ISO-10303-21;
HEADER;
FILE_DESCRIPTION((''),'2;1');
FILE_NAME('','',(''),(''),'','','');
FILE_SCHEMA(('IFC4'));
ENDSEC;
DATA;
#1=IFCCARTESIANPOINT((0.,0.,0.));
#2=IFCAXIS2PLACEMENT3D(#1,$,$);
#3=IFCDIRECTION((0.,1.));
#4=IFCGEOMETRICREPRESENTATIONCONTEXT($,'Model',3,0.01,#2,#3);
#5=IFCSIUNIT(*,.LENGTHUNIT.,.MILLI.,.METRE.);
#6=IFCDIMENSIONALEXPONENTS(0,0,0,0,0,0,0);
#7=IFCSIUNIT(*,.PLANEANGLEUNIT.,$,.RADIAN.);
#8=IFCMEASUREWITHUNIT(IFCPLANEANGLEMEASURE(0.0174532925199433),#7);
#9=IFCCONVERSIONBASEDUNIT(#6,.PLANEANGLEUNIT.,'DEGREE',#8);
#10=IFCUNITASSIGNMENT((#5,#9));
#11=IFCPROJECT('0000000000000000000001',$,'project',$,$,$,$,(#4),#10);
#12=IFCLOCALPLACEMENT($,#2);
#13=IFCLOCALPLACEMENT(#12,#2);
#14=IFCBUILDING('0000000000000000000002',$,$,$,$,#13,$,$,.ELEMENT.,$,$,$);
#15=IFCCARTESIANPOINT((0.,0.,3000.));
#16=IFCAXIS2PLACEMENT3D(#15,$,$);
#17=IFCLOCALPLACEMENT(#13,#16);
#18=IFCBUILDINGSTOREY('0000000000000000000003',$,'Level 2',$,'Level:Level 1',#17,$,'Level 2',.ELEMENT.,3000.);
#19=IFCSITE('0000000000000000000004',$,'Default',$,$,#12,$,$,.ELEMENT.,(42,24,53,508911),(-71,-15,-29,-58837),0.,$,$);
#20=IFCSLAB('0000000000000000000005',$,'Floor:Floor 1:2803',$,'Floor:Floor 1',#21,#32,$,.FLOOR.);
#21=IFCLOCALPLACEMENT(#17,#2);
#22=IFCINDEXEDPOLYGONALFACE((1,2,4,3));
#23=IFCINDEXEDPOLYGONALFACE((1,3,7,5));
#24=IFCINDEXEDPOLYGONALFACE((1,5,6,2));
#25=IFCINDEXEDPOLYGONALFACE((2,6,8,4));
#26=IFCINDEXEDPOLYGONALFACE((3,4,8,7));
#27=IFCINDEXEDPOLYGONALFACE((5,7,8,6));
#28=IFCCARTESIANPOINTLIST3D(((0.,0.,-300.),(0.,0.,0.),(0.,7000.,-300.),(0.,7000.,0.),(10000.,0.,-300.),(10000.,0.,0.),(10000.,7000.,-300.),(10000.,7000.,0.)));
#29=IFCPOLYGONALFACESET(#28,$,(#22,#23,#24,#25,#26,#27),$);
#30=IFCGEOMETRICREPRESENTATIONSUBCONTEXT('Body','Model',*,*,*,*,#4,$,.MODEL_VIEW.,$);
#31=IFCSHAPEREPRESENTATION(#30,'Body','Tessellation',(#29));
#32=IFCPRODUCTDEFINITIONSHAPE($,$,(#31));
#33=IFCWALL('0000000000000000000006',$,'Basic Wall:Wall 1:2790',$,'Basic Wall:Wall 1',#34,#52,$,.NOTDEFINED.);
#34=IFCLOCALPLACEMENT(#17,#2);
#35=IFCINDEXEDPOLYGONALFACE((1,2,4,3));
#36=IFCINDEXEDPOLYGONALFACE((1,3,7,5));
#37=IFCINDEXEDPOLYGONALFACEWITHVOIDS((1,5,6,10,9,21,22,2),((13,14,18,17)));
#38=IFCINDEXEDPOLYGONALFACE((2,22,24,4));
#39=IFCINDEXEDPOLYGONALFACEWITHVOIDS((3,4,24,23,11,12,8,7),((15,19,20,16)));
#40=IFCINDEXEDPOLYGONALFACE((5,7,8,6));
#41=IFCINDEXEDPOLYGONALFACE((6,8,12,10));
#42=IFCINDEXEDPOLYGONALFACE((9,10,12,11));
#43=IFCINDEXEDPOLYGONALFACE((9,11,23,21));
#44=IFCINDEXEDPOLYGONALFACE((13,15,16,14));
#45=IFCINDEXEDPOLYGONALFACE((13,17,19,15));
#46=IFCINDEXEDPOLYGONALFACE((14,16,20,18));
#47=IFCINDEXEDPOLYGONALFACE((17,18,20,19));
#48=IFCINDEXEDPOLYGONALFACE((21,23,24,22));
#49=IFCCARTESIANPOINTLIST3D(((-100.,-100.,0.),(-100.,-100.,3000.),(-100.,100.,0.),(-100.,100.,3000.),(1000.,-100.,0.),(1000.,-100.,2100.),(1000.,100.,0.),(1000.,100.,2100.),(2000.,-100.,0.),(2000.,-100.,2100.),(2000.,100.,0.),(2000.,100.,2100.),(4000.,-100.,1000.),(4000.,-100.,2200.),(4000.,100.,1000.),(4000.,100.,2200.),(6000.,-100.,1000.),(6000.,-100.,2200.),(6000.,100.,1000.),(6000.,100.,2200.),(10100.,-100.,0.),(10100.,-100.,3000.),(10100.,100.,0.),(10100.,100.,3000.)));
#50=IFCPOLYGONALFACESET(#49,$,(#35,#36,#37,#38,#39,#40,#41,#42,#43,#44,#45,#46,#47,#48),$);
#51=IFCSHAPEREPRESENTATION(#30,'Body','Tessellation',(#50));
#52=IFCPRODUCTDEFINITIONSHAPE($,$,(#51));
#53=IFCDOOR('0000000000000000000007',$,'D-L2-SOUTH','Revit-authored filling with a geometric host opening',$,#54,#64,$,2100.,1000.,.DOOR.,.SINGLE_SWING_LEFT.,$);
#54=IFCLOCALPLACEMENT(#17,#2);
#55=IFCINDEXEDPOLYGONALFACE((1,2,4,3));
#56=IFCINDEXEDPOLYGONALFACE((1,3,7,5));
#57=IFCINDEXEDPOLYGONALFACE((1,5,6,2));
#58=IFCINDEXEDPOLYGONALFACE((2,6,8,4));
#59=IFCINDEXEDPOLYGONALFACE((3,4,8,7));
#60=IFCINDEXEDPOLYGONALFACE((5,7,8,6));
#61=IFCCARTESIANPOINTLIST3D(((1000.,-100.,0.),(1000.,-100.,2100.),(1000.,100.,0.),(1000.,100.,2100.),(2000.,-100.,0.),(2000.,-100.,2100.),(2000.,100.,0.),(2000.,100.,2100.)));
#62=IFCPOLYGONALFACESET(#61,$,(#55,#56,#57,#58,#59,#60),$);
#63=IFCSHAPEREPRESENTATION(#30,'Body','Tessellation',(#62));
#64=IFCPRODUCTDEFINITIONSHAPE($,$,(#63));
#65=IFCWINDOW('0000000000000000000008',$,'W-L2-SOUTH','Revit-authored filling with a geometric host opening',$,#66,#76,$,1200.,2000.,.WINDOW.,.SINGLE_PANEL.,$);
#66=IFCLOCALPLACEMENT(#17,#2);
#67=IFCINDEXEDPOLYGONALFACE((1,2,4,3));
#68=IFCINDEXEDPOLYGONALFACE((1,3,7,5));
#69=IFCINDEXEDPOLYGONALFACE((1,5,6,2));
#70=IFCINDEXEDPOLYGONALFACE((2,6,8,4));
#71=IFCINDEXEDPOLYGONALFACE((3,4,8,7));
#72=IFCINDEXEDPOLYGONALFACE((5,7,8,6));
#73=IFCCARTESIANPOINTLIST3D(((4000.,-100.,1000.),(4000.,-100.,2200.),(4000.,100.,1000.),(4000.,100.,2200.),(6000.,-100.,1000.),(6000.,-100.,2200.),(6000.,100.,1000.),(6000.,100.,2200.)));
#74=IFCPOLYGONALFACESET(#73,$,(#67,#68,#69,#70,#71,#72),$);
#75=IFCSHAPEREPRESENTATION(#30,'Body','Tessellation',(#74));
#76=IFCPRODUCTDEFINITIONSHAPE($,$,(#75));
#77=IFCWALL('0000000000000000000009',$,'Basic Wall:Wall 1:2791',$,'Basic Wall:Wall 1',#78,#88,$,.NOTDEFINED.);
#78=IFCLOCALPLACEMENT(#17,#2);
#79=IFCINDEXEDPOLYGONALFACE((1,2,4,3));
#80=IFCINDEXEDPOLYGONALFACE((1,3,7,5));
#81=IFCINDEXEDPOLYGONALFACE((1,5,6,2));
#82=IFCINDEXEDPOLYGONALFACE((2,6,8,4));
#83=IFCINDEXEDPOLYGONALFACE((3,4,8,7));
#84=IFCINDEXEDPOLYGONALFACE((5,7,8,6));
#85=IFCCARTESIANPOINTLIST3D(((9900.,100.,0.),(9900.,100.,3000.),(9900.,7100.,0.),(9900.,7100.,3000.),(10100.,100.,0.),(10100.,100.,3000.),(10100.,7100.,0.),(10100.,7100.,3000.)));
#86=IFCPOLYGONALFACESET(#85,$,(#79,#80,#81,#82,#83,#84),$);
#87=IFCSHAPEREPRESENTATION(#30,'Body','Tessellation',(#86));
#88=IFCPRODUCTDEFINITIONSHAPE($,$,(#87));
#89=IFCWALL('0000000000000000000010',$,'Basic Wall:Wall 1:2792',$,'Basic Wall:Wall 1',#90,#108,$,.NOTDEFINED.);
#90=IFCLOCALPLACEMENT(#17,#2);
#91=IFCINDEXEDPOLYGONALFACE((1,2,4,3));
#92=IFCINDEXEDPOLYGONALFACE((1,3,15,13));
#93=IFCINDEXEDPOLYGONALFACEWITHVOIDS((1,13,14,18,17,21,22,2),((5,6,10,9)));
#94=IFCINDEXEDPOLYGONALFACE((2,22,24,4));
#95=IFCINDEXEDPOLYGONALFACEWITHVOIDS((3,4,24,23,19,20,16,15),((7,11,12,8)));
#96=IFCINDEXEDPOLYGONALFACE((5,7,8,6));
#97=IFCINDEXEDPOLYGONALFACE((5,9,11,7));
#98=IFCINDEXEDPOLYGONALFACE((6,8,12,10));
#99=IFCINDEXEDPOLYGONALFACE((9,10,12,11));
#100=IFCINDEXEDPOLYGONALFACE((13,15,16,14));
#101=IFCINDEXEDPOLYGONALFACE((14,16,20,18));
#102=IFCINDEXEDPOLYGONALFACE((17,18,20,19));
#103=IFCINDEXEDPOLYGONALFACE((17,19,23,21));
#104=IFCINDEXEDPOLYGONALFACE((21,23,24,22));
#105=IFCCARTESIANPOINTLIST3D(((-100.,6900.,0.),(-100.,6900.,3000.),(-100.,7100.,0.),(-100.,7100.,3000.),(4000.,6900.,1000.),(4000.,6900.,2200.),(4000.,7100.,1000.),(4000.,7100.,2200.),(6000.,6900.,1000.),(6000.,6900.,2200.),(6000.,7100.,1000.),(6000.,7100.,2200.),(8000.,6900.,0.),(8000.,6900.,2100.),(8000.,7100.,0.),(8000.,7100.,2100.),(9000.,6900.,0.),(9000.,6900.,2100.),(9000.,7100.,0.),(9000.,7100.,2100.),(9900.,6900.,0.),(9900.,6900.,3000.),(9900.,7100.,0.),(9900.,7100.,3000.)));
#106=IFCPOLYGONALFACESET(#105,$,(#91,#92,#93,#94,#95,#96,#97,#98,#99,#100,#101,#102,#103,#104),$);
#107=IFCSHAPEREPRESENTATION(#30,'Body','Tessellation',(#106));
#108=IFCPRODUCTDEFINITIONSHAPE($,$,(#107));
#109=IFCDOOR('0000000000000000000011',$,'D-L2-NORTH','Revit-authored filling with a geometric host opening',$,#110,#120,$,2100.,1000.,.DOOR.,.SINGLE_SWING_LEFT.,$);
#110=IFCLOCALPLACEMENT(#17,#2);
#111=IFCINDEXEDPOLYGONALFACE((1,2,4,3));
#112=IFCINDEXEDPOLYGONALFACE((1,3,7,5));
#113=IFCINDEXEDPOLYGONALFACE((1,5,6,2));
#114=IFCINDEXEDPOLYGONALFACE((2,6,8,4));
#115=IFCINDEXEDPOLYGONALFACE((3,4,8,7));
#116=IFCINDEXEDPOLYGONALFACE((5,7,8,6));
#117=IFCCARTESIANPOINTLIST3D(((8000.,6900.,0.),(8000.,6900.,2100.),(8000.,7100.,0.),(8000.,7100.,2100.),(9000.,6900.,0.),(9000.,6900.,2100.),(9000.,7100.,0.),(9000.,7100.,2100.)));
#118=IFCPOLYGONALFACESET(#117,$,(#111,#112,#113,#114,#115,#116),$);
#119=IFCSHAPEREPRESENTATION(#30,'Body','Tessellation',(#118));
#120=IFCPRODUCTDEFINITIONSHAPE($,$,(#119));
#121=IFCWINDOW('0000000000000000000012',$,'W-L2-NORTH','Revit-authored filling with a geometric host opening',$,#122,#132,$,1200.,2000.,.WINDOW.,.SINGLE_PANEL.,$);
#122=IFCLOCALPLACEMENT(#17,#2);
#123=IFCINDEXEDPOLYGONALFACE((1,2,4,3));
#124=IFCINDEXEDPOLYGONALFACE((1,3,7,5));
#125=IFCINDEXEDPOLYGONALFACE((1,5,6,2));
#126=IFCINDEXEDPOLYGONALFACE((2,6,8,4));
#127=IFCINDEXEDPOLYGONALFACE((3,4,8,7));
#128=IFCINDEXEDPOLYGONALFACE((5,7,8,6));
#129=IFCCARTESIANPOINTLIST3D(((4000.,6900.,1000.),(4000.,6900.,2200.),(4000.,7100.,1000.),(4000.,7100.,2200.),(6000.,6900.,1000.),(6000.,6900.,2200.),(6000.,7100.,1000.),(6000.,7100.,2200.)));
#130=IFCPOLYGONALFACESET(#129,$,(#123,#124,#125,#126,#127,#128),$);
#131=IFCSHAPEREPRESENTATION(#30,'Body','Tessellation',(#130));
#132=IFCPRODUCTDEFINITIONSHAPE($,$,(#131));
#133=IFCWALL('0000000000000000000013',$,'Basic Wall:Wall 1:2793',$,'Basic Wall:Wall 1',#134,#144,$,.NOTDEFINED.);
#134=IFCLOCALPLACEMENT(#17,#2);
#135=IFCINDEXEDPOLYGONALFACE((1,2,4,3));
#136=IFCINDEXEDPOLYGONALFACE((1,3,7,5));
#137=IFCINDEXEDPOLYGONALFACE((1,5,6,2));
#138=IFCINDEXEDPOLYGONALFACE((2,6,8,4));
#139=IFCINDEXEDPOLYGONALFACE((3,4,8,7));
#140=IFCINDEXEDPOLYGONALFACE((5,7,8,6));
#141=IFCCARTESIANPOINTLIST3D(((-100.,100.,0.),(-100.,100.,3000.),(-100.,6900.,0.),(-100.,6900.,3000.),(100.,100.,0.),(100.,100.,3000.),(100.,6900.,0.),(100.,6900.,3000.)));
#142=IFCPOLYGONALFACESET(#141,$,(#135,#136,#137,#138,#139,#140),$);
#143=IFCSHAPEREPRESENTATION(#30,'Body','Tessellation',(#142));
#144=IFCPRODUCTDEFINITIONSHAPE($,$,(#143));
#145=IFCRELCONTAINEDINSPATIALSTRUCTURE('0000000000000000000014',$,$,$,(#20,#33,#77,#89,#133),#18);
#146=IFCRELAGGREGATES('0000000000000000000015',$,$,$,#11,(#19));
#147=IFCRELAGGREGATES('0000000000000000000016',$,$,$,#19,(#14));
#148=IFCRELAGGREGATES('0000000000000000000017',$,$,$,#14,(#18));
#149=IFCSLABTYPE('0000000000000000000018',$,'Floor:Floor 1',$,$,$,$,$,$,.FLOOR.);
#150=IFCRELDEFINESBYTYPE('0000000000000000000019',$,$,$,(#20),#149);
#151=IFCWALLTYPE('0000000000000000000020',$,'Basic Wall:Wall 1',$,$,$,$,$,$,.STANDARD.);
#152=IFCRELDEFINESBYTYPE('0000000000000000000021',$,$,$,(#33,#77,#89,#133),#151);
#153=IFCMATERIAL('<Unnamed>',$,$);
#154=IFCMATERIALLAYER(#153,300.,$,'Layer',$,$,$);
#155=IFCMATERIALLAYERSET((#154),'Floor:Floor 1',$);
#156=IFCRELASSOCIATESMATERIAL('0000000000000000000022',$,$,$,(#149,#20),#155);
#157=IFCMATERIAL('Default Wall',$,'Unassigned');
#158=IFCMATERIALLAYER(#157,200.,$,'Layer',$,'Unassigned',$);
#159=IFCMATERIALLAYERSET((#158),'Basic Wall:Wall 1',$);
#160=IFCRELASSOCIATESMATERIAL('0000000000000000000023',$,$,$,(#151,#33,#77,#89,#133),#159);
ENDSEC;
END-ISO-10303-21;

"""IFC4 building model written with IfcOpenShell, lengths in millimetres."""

from ifc_helpers import new_model, entity, si_unit, converted_unit, direction, frame, frame_2d, origin, origin_2d, origin_2d_with_axis, place, context, subcontext, project, spatial, rectangle, extrude, material, layer, layer_set, layer_usage, type_object, element, fill, save


model = new_model("IFC4")

# Units and contexts
model_context = context("Model", 3, precision=0.01, world=origin(), true_north=direction((0.0, 1.0)))
body_context = subcontext(model_context, "Body", "Model", "MODEL_VIEW")
ifc_project = project(units=[si_unit("LENGTHUNIT", "METRE", prefix="MILLI"), converted_unit("PLANEANGLEUNIT", "DEGREE", entity("IfcPlaneAngleMeasure", 0.0174532925199433), si_unit("PLANEANGLEUNIT", "RADIAN"), dimensions=[0, 0, 0, 0, 0, 0, 0])], contexts=[model_context])

# Site, building, storey
site_placement = place(None, origin())
site = spatial("IfcSite", under=ifc_project, at=site_placement, Name="Default", CompositionType="ELEMENT", RefLatitude=(42, 24, 53, 508911), RefLongitude=(-71, -15, -29, -58837), RefElevation=0.0)
building_placement = place(site_placement, origin())
building = spatial("IfcBuilding", under=site, at=building_placement, CompositionType="ELEMENT")
storey_placement = place(building_placement, frame((0.0, 0.0, 3000.0)))
storey = spatial("IfcBuildingStorey", under=building, at=storey_placement, Name="Level 2", ObjectType="Level:Level 1", LongName="Level 2", CompositionType="ELEMENT", Elevation=3000.0)

# Slab
ifc_material_1 = material(Name="<Unnamed>")
ifc_layer_1 = layer(ifc_material_1, 300.0, Name="Layer")
ifc_layer_set_1 = layer_set([ifc_layer_1], Name="Floor:Floor 1")
ifc_layer_usage_1 = layer_usage(ifc_layer_set_1, "AXIS3", "POSITIVE", 0.0)
slab_type = type_object("IfcSlabType", Name="Floor:Floor 1", PredefinedType="FLOOR", material=ifc_layer_set_1)
slab_placement = place(storey_placement, origin())
element("IfcSlab", 1, at=slab_placement, inside=storey, type_object=slab_type, material=ifc_layer_usage_1, Name="Floor:Floor 1:2803", ObjectType="Floor:Floor 1", PredefinedType="FLOOR", context=body_context, shape_type="SweptSolid", body=[
    extrude(rectangle(XDim=7000.0, YDim=10000.0, at=origin_2d_with_axis()), frame((5000.0, 3500.0, 0.0), z_axis=(0.0, 0.0, -1.0), x_axis=(0.0, 1.0, 0.0)), (0.0, 0.0, 1.0), 300.0),
])

# Wall, openings, door, window
ifc_material_2 = material(Name="Default Wall", Category="Unassigned")
ifc_layer_2 = layer(ifc_material_2, 200.0, Name="Layer", Category="Unassigned")
ifc_layer_set_2 = layer_set([ifc_layer_2], Name="Basic Wall:Wall 1")
ifc_layer_usage_2 = layer_usage(ifc_layer_set_2, "AXIS2", "NEGATIVE", 100.0)
wall_type = type_object("IfcWallType", Name="Basic Wall:Wall 1", PredefinedType="STANDARD", material=ifc_layer_set_2)
wall_1_placement = place(storey_placement, frame((-100.0, 0.0, 0.0)))
wall_1 = element("IfcWall", 2, at=wall_1_placement, inside=storey, type_object=wall_type, material=ifc_layer_usage_2, Name="Basic Wall:Wall 1:2790", ObjectType="Basic Wall:Wall 1", PredefinedType="NOTDEFINED", context=body_context, shape_type="SweptSolid", body=[
    extrude(rectangle(XDim=10200.0, YDim=200.0, at=frame_2d((5100.0, 0.0), x_axis=(-1.0, 0.0))), origin(), (0.0, 0.0, 1.0), 3000.0),
])
opening_1_placement = place(storey_placement, frame((1000.0, -100.0, 0.0)))
opening_1 = element("IfcOpeningElement", 3, at=opening_1_placement, cuts=wall_1, PredefinedType="OPENING", context=body_context, shape_type="SweptSolid", body=[
    extrude(rectangle(XDim=1000.0, YDim=200.0, at=origin_2d()), frame((500.0, 100.0, 0.0)), (0.0, 0.0, 1.0), 2100.0),
])
opening_2_placement = place(storey_placement, frame((4000.0, -100.0, 1000.0)))
opening_2 = element("IfcOpeningElement", 4, at=opening_2_placement, cuts=wall_1, PredefinedType="OPENING", context=body_context, shape_type="SweptSolid", body=[
    extrude(rectangle(XDim=2000.0, YDim=200.0, at=origin_2d()), frame((1000.0, 100.0, 0.0)), (0.0, 0.0, 1.0), 1200.0),
])
door_1_placement = place(storey_placement, frame((1000.0, -100.0, 0.0)))
door_1 = element("IfcDoor", 5, at=door_1_placement, Name="D-L2-SOUTH", Description="Revit-authored filling with a geometric host opening", OperationType="SINGLE_SWING_LEFT", OverallHeight=2100.0, OverallWidth=1000.0, PredefinedType="DOOR", context=body_context, shape_type="SweptSolid", body=[
    extrude(rectangle(XDim=1000.0, YDim=200.0, at=origin_2d()), frame((500.0, 100.0, 0.0)), (0.0, 0.0, 1.0), 2100.0),
])
fill(opening_1, door_1)
window_1_placement = place(storey_placement, frame((4000.0, -100.0, 1000.0)))
window_1 = element("IfcWindow", 6, at=window_1_placement, Name="W-L2-SOUTH", Description="Revit-authored filling with a geometric host opening", OverallHeight=1200.0, OverallWidth=2000.0, PartitioningType="SINGLE_PANEL", PredefinedType="WINDOW", context=body_context, shape_type="SweptSolid", body=[
    extrude(rectangle(XDim=2000.0, YDim=200.0, at=origin_2d()), frame((1000.0, 100.0, 0.0)), (0.0, 0.0, 1.0), 1200.0),
])
fill(opening_2, window_1)

# Wall
ifc_layer_usage_3 = layer_usage(ifc_layer_set_2, "AXIS2", "NEGATIVE", 100.0)
wall_2_placement = place(storey_placement, frame((10000.0, 100.0, 0.0), z_axis=(0.0, 0.0, 1.0), x_axis=(0.0, 1.0, 0.0)))
element("IfcWall", 7, at=wall_2_placement, inside=storey, type_object=wall_type, material=ifc_layer_usage_3, Name="Basic Wall:Wall 1:2791", ObjectType="Basic Wall:Wall 1", PredefinedType="NOTDEFINED", context=body_context, shape_type="SweptSolid", body=[
    extrude(rectangle(XDim=7000.0, YDim=200.0, at=frame_2d((3500.0, 0.0), x_axis=(-1.0, 0.0))), origin(), (0.0, 0.0, 1.0), 3000.0),
])

# Wall, openings, door, window
ifc_layer_usage_4 = layer_usage(ifc_layer_set_2, "AXIS2", "NEGATIVE", 100.0)
wall_3_placement = place(storey_placement, frame((9900.0, 7000.0, 0.0), z_axis=(0.0, 0.0, 1.0), x_axis=(-1.0, 0.0, 0.0)))
wall_3 = element("IfcWall", 8, at=wall_3_placement, inside=storey, type_object=wall_type, material=ifc_layer_usage_4, Name="Basic Wall:Wall 1:2792", ObjectType="Basic Wall:Wall 1", PredefinedType="NOTDEFINED", context=body_context, shape_type="SweptSolid", body=[
    extrude(rectangle(XDim=10000.0, YDim=200.0, at=frame_2d((5000.0, 0.0), x_axis=(-1.0, 0.0))), origin(), (0.0, 0.0, 1.0), 3000.0),
])
opening_3_placement = place(storey_placement, frame((8000.0, 6900.0, 0.0)))
opening_3 = element("IfcOpeningElement", 9, at=opening_3_placement, cuts=wall_3, PredefinedType="OPENING", context=body_context, shape_type="SweptSolid", body=[
    extrude(rectangle(XDim=1000.0, YDim=200.0, at=origin_2d()), frame((500.0, 100.0, 0.0)), (0.0, 0.0, 1.0), 2100.0),
])
opening_4_placement = place(storey_placement, frame((4000.0, 6900.0, 1000.0)))
opening_4 = element("IfcOpeningElement", 10, at=opening_4_placement, cuts=wall_3, PredefinedType="OPENING", context=body_context, shape_type="SweptSolid", body=[
    extrude(rectangle(XDim=2000.0, YDim=200.0, at=origin_2d()), frame((1000.0, 100.0, 0.0)), (0.0, 0.0, 1.0), 1200.0),
])
door_2_placement = place(storey_placement, frame((8000.0, 6900.0, 0.0)))
door_2 = element("IfcDoor", 11, at=door_2_placement, Name="D-L2-NORTH", Description="Revit-authored filling with a geometric host opening", OperationType="SINGLE_SWING_LEFT", OverallHeight=2100.0, OverallWidth=1000.0, PredefinedType="DOOR", context=body_context, shape_type="SweptSolid", body=[
    extrude(rectangle(XDim=1000.0, YDim=200.0, at=origin_2d()), frame((500.0, 100.0, 0.0)), (0.0, 0.0, 1.0), 2100.0),
])
fill(opening_3, door_2)
window_2_placement = place(storey_placement, frame((4000.0, 6900.0, 1000.0)))
window_2 = element("IfcWindow", 12, at=window_2_placement, Name="W-L2-NORTH", Description="Revit-authored filling with a geometric host opening", OverallHeight=1200.0, OverallWidth=2000.0, PartitioningType="SINGLE_PANEL", PredefinedType="WINDOW", context=body_context, shape_type="SweptSolid", body=[
    extrude(rectangle(XDim=2000.0, YDim=200.0, at=origin_2d()), frame((1000.0, 100.0, 0.0)), (0.0, 0.0, 1.0), 1200.0),
])
fill(opening_4, window_2)

# Wall
ifc_layer_usage_5 = layer_usage(ifc_layer_set_2, "AXIS2", "NEGATIVE", 100.0)
wall_4_placement = place(storey_placement, frame((0.0, 6900.0, 0.0), z_axis=(0.0, 0.0, 1.0), x_axis=(0.0, -1.0, 0.0)))
element("IfcWall", 13, at=wall_4_placement, inside=storey, type_object=wall_type, material=ifc_layer_usage_5, Name="Basic Wall:Wall 1:2793", ObjectType="Basic Wall:Wall 1", PredefinedType="NOTDEFINED", context=body_context, shape_type="SweptSolid", body=[
    extrude(rectangle(XDim=6800.0, YDim=200.0, at=frame_2d((3400.0, 0.0), x_axis=(-1.0, 0.0))), origin(), (0.0, 0.0, 1.0), 3000.0),
])

save(model, "model.ifc")
